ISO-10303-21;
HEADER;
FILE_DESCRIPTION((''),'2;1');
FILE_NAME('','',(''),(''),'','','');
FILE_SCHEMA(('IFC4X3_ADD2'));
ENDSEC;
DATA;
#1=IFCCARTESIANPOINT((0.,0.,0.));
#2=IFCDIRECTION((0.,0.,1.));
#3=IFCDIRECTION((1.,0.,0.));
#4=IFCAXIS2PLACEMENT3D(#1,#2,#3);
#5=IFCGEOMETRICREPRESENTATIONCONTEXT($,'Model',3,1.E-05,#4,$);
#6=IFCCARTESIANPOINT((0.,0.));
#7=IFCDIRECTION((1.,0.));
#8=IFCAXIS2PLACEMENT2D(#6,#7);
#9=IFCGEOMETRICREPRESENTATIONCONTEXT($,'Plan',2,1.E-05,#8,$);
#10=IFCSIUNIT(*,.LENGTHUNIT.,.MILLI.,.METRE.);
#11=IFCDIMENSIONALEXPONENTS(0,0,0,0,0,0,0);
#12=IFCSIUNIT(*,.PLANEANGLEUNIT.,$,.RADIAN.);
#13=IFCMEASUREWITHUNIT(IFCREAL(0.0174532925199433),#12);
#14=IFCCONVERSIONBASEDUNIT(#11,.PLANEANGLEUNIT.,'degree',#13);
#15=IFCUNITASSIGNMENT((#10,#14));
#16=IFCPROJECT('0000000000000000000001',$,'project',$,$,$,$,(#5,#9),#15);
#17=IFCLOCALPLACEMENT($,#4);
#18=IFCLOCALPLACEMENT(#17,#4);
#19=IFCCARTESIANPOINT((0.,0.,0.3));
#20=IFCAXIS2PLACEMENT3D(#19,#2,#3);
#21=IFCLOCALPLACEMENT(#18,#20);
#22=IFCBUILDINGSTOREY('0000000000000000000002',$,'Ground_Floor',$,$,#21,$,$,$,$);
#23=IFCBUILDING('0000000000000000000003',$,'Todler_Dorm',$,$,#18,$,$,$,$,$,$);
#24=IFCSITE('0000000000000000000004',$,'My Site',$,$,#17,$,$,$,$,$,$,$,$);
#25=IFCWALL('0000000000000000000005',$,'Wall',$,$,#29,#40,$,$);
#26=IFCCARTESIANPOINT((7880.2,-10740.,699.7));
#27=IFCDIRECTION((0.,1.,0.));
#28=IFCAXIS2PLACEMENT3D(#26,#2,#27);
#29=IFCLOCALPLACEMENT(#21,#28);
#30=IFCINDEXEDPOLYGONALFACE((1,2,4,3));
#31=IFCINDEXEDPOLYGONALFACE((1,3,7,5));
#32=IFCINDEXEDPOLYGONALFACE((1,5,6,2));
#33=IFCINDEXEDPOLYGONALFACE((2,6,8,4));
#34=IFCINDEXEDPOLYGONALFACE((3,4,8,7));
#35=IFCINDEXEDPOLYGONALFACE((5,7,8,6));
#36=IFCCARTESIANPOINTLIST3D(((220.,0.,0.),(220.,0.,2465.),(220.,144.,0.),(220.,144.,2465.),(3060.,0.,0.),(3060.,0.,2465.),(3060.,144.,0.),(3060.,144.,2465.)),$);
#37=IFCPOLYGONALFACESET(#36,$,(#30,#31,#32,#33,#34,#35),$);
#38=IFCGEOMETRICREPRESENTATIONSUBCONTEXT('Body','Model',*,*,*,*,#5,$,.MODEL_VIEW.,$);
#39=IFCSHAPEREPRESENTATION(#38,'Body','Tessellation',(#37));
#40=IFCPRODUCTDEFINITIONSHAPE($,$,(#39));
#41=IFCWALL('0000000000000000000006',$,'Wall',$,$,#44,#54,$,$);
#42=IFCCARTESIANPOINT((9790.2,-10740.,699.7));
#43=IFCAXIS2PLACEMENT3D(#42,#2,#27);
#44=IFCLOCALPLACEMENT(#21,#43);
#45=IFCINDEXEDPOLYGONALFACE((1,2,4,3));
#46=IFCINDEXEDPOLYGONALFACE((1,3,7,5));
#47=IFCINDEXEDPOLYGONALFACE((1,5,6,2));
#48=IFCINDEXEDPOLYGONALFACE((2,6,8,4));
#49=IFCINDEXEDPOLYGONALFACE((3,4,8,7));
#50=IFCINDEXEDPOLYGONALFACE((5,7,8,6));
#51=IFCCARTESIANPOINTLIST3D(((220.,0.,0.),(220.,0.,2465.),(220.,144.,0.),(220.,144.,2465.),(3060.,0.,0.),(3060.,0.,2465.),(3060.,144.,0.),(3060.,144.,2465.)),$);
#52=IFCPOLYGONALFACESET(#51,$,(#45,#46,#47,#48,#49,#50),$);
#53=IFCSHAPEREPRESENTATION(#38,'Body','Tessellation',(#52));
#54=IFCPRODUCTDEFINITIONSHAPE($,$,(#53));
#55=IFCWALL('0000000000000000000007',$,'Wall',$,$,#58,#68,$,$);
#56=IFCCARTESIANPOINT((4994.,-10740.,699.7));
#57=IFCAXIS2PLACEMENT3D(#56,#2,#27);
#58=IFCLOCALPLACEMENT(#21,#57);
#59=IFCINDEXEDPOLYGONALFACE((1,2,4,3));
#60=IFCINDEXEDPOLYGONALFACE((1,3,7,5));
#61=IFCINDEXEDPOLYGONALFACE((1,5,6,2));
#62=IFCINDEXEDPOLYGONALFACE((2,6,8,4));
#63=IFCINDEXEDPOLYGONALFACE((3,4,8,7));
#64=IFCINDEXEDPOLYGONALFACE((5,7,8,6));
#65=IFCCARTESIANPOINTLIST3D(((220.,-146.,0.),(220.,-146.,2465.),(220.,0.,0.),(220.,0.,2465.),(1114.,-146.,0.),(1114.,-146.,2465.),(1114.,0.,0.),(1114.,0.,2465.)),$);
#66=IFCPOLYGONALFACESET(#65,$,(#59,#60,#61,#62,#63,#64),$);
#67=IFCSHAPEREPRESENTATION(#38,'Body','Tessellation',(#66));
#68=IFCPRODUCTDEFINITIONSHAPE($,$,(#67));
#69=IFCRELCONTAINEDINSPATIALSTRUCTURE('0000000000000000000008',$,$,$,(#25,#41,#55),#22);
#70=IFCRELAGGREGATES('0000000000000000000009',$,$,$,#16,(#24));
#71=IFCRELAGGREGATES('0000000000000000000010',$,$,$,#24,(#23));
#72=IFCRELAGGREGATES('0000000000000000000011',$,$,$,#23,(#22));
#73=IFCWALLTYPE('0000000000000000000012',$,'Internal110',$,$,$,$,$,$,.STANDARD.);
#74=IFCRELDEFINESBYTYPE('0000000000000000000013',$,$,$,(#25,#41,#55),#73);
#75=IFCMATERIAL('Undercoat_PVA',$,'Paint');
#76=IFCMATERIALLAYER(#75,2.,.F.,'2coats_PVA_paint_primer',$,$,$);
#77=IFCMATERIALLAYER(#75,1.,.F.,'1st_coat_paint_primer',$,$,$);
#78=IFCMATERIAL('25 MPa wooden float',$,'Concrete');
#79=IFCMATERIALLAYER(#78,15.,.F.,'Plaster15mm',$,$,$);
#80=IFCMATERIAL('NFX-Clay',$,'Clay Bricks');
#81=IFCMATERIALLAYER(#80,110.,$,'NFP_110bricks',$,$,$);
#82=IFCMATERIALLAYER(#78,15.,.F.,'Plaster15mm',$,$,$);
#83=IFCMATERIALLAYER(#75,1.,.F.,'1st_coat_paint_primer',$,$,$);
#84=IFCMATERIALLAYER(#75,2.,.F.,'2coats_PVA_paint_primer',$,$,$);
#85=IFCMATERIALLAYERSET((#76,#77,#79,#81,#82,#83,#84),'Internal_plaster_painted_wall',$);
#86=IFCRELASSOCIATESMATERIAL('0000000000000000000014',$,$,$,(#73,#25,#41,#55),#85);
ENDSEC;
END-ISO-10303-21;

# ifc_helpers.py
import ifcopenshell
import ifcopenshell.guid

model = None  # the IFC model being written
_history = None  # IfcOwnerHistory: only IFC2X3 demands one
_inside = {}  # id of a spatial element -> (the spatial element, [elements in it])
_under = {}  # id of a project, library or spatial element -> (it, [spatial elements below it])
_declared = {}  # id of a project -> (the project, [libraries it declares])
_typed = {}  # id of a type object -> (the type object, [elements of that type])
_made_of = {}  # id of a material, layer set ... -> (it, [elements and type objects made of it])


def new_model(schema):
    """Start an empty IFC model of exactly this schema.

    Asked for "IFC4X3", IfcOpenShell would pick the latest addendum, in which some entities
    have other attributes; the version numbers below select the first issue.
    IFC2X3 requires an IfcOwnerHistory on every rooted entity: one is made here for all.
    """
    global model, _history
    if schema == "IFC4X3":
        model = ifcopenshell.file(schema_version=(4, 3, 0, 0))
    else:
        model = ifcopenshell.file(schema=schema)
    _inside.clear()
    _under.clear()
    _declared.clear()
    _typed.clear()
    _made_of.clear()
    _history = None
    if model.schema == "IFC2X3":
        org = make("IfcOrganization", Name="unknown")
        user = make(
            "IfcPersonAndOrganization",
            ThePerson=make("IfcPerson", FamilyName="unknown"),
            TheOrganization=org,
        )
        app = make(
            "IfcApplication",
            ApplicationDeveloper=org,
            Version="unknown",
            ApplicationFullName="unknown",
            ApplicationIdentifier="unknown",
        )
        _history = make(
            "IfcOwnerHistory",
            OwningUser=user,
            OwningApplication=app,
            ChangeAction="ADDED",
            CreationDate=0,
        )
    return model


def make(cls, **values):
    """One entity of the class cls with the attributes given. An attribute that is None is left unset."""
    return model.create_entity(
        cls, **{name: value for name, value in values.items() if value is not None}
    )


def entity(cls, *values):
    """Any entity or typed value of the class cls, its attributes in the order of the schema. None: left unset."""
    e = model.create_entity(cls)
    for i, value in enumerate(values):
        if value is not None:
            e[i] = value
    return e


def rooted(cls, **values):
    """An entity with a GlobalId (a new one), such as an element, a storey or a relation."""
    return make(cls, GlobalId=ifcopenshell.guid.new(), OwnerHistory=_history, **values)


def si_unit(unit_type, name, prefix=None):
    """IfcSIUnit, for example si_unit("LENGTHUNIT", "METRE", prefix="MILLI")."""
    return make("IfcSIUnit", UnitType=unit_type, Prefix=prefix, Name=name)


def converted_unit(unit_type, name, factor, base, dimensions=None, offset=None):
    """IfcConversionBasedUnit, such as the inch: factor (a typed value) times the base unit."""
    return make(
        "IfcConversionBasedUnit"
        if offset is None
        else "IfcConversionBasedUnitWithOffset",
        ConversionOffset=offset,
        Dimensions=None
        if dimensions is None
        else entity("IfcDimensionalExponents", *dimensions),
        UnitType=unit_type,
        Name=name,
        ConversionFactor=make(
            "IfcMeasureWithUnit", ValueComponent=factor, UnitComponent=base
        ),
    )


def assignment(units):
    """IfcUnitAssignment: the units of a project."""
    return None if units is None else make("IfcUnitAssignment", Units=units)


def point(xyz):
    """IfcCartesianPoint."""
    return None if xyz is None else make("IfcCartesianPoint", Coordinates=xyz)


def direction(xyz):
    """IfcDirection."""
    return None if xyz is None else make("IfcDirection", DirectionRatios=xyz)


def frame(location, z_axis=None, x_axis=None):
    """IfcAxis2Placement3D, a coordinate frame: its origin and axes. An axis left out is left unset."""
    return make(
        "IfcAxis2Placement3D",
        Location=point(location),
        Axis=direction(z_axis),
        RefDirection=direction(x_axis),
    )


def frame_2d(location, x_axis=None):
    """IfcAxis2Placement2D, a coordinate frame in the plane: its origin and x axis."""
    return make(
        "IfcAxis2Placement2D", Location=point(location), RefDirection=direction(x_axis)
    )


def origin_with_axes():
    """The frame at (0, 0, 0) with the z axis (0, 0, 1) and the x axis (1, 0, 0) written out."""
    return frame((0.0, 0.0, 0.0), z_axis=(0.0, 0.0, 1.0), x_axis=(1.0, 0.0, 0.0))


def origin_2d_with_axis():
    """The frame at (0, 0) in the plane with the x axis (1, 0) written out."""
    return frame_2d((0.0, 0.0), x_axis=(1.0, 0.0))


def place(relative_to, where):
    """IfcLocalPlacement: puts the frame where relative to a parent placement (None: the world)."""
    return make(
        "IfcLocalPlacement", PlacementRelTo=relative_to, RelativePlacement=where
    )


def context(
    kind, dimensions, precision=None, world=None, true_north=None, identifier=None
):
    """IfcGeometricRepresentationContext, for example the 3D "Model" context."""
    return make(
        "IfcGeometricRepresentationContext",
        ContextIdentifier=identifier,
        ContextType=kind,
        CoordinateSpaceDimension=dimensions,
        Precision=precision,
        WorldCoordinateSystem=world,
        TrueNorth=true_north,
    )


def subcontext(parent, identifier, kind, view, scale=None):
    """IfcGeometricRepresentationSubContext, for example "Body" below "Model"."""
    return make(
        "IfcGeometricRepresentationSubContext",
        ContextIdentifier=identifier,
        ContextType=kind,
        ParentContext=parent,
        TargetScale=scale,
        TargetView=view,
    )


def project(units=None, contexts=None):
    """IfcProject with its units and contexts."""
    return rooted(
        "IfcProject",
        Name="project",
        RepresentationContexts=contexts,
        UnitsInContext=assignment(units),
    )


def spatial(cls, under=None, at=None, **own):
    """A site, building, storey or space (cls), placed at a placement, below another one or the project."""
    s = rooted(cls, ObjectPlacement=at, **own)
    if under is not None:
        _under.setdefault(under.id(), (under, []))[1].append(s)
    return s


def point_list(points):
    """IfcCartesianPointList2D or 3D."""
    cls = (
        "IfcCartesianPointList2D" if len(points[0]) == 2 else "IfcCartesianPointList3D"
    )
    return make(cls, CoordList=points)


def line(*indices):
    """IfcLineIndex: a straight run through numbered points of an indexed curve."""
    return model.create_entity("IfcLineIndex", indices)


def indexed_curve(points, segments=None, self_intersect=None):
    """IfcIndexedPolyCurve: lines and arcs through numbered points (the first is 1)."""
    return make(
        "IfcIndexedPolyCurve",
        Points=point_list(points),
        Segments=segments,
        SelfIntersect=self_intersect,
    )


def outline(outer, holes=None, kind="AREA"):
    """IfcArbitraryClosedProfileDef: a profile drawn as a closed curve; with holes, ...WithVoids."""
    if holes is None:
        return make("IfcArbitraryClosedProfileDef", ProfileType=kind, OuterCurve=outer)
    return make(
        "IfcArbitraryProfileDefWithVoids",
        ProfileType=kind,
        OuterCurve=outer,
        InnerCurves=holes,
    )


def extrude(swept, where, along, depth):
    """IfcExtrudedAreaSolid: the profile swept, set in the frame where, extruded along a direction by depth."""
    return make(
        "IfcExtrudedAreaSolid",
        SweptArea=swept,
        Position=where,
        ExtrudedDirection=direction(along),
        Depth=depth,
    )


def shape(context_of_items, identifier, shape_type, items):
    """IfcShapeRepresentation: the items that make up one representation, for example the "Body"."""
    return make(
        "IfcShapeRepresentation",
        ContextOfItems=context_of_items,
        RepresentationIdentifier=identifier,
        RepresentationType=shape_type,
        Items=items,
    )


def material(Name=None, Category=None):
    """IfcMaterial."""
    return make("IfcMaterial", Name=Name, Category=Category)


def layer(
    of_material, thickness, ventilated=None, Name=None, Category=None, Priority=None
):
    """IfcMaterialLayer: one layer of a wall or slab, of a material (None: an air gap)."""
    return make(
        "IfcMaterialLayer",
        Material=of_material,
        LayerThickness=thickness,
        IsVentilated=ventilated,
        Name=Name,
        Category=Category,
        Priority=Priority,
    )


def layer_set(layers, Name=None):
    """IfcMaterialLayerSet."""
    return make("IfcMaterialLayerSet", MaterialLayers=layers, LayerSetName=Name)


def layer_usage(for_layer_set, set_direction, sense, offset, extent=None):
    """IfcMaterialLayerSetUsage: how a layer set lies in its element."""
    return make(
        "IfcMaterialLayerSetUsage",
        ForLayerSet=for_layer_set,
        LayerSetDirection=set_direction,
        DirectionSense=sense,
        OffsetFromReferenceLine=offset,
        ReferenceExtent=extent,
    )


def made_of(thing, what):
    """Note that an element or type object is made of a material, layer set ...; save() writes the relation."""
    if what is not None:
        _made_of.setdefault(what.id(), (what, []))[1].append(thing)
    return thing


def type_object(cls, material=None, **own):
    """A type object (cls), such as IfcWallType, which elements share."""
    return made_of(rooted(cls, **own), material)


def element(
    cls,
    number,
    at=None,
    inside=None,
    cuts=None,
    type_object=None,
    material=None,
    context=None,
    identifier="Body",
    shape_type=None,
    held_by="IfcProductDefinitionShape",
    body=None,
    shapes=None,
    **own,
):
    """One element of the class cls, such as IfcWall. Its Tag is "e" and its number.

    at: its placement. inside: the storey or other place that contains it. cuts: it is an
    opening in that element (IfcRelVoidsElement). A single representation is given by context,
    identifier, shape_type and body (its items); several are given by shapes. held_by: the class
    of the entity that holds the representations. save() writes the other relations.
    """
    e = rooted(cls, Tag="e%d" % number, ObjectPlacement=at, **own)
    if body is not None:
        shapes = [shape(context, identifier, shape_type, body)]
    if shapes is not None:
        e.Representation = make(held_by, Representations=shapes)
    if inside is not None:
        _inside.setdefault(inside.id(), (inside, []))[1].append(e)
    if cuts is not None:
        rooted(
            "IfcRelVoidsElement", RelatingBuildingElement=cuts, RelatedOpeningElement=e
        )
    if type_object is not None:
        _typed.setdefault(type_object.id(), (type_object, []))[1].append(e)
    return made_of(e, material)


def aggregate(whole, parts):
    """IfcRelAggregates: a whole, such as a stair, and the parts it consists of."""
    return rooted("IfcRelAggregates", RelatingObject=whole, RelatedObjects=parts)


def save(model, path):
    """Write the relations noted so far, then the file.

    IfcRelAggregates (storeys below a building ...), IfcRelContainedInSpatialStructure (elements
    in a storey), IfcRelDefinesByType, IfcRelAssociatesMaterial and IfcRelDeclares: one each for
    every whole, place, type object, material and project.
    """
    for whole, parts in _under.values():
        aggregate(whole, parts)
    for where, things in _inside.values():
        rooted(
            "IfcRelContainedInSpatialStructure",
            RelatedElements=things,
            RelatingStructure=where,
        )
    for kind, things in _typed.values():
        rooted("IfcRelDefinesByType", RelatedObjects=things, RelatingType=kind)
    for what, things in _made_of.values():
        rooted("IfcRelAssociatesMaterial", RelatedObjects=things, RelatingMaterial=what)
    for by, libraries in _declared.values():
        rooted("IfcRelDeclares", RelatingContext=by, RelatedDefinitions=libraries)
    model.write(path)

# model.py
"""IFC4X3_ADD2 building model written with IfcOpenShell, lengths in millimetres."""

from ifc_helpers import new_model, entity, si_unit, converted_unit, frame, origin_with_axes, origin_2d_with_axis, place, context, subcontext, project, spatial, line, indexed_curve, outline, extrude, material, layer, layer_set, layer_usage, type_object, element, save


model = new_model("IFC4X3_ADD2")

# Units and contexts
model_context = context("Model", 3, precision=1e-05, world=origin_with_axes())
plan_context = context("Plan", 2, precision=1e-05, world=origin_2d_with_axis())
body_context_1 = subcontext(model_context, "Body", "Model", "MODEL_VIEW")
ifc_project = project(units=[si_unit("LENGTHUNIT", "METRE", prefix="MILLI"), converted_unit("PLANEANGLEUNIT", "degree", entity("IfcReal", 0.0174532925199433), si_unit("PLANEANGLEUNIT", "RADIAN"), dimensions=[0, 0, 0, 0, 0, 0, 0])], contexts=[model_context, plan_context])

# Site, building, storey
site_placement = place(None, origin_with_axes())
site = spatial("IfcSite", under=ifc_project, at=site_placement, Name="My Site")
building_placement = place(site_placement, origin_with_axes())
building = spatial("IfcBuilding", under=site, at=building_placement, Name="Todler_Dorm")
storey_placement = place(building_placement, frame((0.0, 0.0, 0.3), z_axis=(0.0, 0.0, 1.0), x_axis=(1.0, 0.0, 0.0)))
storey = spatial("IfcBuildingStorey", under=building, at=storey_placement, Name="Ground_Floor")

# Shared definitions
ifc_material_1 = material(Name="Undercoat_PVA", Category="Paint")
ifc_layer_1 = layer(ifc_material_1, 2.0, ventilated=False, Name="2coats_PVA_paint_primer")
ifc_layer_2 = layer(ifc_material_1, 1.0, ventilated=False, Name="1st_coat_paint_primer")
ifc_material_2 = material(Name="25 MPa wooden float", Category="Concrete")
ifc_layer_3 = layer(ifc_material_2, 15.0, ventilated=False, Name="Plaster15mm")
ifc_material_3 = material(Name="NFX-Clay", Category="Clay Bricks")
ifc_layer_4 = layer(ifc_material_3, 110.0, Name="NFP_110bricks")
ifc_layer_5 = layer(ifc_material_2, 15.0, ventilated=False, Name="Plaster15mm")
ifc_layer_6 = layer(ifc_material_1, 1.0, ventilated=False, Name="1st_coat_paint_primer")
ifc_layer_7 = layer(ifc_material_1, 2.0, ventilated=False, Name="2coats_PVA_paint_primer")
ifc_layer_set_1 = layer_set([ifc_layer_1, ifc_layer_2, ifc_layer_3, ifc_layer_4, ifc_layer_5, ifc_layer_6, ifc_layer_7], Name="Internal_plaster_painted_wall")
wall_type_1 = type_object("IfcWallType", Name="Internal110", PredefinedType="STANDARD", material=ifc_layer_set_1)

# Walls
ifc_layer_usage_1 = layer_usage(ifc_layer_set_1, "AXIS2", "POSITIVE", 0.0)
wall_1_placement = place(storey_placement, frame((7880.2, -10740.0, 699.7), z_axis=(0.0, 0.0, 1.0), x_axis=(0.0, 1.0, 0.0)))
element("IfcWall", 1, at=wall_1_placement, inside=storey, type_object=wall_type_1, material=ifc_layer_usage_1, Name="Wall", context=body_context_1, shape_type="SweptSolid", body=[
    extrude(outline(indexed_curve([(220.0, 0.0), (220.0, 144.0), (3060.0, 144.0), (3060.0, 0.0)], segments=[line(1, 2, 3, 4, 1)])), origin_with_axes(), (0.0, 0.0, 1.0), 2465.0),
])
ifc_layer_usage_2 = layer_usage(ifc_layer_set_1, "AXIS2", "POSITIVE", 0.0)
wall_2_placement = place(storey_placement, frame((9790.2, -10740.0, 699.7), z_axis=(0.0, 0.0, 1.0), x_axis=(0.0, 1.0, 0.0)))
element("IfcWall", 2, at=wall_2_placement, inside=storey, type_object=wall_type_1, material=ifc_layer_usage_2, Name="Wall", context=body_context_1, shape_type="SweptSolid", body=[
    extrude(outline(indexed_curve([(220.0, 0.0), (220.0, 144.0), (3060.0, 144.0), (3060.0, 0.0)], segments=[line(1, 2, 3, 4, 1)])), origin_with_axes(), (0.0, 0.0, 1.0), 2465.0),
])
ifc_layer_usage_3 = layer_usage(ifc_layer_set_1, "AXIS2", "NEGATIVE", 0.0)
wall_3_placement = place(storey_placement, frame((4994.0, -10740.0, 699.7), z_axis=(0.0, 0.0, 1.0), x_axis=(0.0, 1.0, 0.0)))
element("IfcWall", 3, at=wall_3_placement, inside=storey, type_object=wall_type_1, material=ifc_layer_usage_3, Name="Wall", context=body_context_1, shape_type="SweptSolid", body=[
    extrude(outline(indexed_curve([(220.0, -146.0), (220.0, 0.0), (1114.0, 0.0), (1114.0, -146.0)], segments=[line(1, 2, 3, 4, 1)])), origin_with_axes(), (0.0, 0.0, 1.0), 2465.0),
])

save(model, "model.ifc")
